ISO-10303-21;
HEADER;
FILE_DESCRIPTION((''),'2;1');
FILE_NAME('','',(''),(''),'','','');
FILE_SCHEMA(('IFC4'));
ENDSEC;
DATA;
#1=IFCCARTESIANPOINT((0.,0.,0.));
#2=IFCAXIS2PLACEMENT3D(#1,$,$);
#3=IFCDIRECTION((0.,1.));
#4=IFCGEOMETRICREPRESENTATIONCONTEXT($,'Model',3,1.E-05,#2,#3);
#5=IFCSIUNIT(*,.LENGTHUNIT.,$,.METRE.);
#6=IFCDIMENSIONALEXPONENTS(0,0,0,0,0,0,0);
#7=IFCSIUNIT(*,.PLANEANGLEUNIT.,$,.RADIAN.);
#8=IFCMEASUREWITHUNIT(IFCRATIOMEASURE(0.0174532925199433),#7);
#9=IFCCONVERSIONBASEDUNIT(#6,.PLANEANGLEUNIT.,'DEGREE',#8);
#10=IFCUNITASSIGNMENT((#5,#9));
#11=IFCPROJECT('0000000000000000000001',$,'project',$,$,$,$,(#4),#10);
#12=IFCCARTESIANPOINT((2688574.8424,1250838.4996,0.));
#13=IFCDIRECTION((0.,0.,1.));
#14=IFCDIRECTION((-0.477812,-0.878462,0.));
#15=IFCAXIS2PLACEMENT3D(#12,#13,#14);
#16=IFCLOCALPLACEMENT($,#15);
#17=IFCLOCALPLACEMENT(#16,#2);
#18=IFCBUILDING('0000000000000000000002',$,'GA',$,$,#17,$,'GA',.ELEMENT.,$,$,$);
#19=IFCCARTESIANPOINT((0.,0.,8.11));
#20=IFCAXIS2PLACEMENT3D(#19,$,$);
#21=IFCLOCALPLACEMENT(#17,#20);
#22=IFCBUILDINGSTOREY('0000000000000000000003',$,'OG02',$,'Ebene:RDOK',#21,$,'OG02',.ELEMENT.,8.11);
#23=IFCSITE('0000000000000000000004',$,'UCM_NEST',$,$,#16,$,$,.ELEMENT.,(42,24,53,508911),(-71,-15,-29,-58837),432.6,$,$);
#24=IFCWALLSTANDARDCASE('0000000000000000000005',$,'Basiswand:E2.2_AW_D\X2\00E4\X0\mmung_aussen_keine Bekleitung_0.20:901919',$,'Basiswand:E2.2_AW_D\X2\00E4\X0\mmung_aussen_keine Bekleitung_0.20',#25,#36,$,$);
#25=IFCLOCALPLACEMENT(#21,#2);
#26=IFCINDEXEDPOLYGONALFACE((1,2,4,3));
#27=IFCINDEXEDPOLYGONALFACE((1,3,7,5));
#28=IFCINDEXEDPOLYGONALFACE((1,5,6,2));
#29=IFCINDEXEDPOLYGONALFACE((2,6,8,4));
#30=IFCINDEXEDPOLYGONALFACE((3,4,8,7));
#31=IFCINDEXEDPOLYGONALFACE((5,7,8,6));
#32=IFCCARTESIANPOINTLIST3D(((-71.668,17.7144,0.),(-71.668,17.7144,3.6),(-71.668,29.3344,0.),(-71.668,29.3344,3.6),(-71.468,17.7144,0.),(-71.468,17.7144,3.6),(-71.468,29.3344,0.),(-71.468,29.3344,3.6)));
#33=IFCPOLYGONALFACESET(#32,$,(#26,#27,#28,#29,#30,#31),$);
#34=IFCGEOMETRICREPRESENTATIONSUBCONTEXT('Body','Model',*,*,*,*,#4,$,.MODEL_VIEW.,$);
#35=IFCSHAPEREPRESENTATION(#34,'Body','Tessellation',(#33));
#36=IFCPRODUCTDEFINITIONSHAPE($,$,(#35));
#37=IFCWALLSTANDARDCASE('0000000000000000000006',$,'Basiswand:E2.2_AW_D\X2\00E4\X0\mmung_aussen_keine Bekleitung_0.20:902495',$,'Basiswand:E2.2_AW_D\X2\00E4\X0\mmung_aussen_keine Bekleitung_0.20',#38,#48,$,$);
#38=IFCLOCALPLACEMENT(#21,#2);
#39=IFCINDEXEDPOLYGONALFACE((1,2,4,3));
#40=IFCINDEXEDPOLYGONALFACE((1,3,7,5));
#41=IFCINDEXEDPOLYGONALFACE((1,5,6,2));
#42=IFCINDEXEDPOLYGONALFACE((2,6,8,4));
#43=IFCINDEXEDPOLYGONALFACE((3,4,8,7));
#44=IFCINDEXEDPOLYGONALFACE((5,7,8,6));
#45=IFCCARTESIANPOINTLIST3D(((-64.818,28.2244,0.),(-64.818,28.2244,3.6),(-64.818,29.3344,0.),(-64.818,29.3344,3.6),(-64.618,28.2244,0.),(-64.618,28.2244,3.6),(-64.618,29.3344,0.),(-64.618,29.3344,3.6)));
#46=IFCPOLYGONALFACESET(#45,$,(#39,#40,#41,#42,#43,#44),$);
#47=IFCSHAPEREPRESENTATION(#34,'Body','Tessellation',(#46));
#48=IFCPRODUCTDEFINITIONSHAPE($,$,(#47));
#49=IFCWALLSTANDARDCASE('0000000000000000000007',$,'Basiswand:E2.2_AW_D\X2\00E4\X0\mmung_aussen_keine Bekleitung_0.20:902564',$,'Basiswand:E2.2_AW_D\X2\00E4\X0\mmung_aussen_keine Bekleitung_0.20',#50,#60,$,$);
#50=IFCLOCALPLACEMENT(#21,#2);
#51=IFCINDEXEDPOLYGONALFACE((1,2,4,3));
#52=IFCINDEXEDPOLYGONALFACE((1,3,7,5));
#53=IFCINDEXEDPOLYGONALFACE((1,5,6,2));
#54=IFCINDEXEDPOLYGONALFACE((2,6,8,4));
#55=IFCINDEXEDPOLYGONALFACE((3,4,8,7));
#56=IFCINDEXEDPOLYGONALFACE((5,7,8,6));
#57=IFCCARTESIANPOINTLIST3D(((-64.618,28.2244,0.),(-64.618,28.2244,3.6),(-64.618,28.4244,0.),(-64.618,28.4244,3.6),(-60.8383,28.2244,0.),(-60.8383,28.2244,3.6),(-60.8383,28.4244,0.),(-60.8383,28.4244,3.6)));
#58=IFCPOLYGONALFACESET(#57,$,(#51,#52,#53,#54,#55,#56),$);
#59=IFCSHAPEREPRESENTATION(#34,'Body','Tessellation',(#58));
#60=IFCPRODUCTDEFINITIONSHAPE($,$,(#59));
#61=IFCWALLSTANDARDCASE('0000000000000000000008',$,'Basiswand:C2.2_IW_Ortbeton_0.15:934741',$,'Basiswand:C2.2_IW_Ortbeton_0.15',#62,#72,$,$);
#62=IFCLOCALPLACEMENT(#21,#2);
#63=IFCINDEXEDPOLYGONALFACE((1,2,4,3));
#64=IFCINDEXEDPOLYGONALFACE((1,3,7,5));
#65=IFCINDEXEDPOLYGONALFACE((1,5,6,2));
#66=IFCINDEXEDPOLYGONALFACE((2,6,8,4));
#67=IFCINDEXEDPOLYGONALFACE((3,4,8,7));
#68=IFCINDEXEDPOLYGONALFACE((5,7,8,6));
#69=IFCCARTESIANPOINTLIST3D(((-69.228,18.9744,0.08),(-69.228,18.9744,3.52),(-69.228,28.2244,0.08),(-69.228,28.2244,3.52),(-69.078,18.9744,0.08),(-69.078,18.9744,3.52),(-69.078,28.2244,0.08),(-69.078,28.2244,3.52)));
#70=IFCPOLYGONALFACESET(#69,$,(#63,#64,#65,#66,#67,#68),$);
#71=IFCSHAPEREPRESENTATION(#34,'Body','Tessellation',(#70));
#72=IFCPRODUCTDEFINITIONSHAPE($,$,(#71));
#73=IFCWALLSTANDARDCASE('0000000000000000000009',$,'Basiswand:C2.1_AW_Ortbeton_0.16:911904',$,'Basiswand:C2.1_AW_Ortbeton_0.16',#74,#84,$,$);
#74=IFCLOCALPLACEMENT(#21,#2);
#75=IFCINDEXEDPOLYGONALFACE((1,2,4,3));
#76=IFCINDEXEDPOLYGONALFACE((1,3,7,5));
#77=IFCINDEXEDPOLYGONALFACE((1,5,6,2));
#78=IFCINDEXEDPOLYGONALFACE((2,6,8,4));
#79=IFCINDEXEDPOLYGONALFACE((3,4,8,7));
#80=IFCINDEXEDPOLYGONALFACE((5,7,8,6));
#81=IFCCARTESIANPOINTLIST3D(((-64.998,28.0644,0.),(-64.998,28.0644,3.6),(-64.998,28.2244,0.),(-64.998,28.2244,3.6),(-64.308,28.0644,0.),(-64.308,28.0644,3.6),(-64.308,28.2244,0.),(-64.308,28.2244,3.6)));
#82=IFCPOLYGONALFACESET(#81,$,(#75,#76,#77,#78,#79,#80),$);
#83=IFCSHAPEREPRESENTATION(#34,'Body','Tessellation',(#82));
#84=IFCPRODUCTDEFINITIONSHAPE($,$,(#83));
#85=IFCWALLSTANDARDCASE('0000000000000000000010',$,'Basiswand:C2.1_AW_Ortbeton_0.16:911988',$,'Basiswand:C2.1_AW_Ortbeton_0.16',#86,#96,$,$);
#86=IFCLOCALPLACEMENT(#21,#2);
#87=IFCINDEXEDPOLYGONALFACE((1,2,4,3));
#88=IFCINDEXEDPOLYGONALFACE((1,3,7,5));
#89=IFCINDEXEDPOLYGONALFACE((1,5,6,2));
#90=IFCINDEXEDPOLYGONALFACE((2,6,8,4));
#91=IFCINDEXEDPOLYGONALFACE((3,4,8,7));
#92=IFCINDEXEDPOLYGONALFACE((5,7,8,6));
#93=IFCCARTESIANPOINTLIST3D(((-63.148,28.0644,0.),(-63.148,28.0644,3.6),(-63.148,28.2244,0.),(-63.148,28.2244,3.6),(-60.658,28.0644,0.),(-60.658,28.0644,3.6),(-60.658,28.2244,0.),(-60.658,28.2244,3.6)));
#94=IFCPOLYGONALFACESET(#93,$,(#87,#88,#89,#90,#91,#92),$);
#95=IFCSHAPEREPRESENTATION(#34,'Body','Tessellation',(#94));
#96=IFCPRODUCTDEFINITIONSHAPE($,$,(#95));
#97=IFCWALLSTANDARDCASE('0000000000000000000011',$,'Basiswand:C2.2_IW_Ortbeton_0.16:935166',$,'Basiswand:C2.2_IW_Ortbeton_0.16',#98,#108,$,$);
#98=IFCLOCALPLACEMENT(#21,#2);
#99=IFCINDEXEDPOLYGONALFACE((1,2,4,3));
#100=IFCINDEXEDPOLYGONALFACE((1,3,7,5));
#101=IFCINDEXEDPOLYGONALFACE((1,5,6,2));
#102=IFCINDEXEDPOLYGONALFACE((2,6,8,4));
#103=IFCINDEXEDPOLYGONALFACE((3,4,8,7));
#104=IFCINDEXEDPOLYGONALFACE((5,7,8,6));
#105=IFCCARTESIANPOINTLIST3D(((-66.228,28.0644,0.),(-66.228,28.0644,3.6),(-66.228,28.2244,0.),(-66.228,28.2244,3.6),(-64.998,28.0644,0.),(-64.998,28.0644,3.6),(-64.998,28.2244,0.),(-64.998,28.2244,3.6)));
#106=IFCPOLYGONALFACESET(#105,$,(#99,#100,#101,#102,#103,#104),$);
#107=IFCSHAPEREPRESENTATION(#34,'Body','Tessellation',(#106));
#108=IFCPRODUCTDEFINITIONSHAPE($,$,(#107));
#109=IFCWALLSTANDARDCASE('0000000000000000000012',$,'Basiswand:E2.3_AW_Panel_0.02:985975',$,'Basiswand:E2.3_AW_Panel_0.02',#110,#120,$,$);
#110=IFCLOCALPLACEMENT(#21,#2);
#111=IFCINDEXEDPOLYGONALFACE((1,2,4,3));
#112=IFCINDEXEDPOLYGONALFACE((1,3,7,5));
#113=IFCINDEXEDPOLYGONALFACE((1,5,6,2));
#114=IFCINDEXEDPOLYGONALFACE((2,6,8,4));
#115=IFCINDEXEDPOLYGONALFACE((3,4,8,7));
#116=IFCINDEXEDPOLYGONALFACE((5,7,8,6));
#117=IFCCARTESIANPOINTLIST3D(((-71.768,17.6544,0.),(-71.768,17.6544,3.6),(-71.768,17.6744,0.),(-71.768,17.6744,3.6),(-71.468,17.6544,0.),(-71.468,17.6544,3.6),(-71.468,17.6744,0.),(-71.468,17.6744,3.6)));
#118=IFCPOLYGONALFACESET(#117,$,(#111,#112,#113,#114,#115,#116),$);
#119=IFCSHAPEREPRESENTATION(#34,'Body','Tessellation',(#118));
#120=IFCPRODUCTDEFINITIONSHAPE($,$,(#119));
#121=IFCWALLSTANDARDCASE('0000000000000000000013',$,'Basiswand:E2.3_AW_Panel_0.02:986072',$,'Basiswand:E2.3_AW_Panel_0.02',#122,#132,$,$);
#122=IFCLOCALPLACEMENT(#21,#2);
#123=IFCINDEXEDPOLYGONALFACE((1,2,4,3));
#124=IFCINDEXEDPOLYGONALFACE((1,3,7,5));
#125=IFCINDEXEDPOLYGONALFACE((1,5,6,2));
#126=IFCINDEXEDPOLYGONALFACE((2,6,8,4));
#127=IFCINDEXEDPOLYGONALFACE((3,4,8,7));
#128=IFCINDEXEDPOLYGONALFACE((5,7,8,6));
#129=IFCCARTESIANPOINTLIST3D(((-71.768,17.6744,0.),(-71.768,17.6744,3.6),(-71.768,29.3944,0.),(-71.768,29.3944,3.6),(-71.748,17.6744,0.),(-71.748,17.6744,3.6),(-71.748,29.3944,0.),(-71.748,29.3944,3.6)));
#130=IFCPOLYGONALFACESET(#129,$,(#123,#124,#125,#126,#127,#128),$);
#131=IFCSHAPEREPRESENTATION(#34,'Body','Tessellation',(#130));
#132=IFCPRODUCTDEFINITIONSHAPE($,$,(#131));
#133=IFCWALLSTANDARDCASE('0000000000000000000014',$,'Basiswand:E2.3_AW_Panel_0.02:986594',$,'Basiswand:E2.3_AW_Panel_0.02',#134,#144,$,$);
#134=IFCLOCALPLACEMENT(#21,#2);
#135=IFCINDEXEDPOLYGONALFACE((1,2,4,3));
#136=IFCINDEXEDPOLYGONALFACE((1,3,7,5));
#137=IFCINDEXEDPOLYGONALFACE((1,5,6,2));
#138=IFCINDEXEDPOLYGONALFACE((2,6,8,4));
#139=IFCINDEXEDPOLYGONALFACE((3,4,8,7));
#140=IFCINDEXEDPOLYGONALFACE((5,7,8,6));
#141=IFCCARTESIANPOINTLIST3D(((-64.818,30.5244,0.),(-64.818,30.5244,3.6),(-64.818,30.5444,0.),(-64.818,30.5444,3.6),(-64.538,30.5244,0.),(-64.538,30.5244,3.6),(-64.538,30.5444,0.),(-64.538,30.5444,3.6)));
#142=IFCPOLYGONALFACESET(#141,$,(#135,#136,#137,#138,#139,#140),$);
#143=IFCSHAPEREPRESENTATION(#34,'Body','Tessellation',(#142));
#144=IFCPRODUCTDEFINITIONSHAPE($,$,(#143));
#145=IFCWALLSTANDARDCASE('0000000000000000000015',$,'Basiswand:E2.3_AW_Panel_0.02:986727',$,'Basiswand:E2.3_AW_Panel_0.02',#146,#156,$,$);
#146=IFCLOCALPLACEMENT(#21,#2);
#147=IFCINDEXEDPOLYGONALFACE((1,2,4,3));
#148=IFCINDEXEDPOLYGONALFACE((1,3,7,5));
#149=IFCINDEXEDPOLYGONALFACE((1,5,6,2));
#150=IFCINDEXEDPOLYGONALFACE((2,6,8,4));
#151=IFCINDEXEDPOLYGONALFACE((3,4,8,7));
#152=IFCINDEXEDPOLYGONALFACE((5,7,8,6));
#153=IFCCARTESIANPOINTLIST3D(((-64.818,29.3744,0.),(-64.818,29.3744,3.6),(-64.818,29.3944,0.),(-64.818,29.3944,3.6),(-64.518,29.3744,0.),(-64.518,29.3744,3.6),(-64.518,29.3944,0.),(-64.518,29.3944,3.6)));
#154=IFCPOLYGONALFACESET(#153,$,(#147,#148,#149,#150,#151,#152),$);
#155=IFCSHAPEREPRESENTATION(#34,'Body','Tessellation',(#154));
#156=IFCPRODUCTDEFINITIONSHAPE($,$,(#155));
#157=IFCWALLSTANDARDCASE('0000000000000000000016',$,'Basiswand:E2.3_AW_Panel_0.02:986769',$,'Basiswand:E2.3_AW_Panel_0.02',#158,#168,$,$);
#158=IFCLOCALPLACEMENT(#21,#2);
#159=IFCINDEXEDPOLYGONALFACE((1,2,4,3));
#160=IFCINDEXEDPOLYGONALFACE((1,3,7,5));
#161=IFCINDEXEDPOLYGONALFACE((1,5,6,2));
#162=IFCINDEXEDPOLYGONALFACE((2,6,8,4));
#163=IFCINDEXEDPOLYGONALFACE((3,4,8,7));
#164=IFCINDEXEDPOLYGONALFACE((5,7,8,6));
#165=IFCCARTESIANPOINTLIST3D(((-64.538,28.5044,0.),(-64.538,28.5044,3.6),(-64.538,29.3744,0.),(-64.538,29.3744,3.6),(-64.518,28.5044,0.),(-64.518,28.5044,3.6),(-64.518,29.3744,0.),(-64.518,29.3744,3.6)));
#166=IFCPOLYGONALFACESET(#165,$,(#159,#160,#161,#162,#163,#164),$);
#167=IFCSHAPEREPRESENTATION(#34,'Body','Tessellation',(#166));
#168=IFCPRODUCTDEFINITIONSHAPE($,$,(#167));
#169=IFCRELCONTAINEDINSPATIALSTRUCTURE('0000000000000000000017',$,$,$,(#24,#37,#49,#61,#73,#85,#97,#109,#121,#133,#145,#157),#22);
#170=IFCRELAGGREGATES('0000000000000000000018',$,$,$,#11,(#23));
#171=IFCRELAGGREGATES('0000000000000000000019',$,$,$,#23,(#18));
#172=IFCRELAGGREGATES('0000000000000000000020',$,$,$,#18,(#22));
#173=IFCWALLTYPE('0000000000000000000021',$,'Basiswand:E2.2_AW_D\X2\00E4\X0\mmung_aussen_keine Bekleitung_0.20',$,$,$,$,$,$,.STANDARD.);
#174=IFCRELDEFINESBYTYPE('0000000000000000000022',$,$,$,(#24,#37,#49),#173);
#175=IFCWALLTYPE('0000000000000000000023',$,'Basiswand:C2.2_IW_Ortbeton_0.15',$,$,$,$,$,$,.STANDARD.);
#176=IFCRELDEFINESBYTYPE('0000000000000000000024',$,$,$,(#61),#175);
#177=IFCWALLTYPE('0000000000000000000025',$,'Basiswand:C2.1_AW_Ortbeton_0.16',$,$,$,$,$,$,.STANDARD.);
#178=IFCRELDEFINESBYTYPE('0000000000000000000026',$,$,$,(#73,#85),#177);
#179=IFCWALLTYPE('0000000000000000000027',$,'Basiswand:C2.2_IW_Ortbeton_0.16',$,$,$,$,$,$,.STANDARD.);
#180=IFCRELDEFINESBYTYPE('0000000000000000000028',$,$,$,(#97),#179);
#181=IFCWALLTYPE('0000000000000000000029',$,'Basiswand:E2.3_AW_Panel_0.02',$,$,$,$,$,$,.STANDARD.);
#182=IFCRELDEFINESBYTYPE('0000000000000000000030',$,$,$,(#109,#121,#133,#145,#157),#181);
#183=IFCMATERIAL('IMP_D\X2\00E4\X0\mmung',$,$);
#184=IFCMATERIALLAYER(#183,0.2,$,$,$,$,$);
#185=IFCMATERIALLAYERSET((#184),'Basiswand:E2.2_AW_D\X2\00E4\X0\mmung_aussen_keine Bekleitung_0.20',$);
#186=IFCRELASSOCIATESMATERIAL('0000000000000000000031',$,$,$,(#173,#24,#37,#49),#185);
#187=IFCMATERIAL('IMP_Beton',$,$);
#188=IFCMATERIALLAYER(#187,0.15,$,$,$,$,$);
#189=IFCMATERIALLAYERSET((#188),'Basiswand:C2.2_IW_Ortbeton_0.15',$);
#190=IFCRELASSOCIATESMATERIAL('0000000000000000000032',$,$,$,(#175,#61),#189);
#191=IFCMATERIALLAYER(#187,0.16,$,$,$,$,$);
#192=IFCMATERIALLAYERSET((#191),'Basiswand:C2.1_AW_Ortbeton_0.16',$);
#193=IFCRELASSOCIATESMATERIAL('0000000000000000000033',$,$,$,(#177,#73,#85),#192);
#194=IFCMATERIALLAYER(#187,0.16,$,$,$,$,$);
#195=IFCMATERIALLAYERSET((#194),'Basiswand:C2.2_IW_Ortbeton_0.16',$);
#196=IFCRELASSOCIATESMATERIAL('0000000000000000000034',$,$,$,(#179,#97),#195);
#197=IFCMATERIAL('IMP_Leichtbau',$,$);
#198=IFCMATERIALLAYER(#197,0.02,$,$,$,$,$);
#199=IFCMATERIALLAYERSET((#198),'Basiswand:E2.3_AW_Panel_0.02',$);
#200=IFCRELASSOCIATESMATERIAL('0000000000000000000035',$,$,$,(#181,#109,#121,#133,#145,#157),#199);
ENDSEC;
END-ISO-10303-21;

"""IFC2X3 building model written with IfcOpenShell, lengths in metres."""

from ifc_helpers import new_model, entity, si_unit, converted_unit, direction, frame, frame_2d, origin, place, context, subcontext, project, spatial, polyline, rectangle, extrude, clip, bounded_halfspace, material, layer, layer_set, layer_usage, type_object, element, save


model = new_model("IFC2X3")

# Units and contexts
model_context = context("Model", 3, precision=1e-05, world=origin(), true_north=direction((0.0, 1.0)))
body_context = subcontext(model_context, "Body", "Model", "MODEL_VIEW")
ifc_project = project(units=[si_unit("LENGTHUNIT", "METRE"), converted_unit("PLANEANGLEUNIT", "DEGREE", entity("IfcRatioMeasure", 0.0174532925199433), si_unit("PLANEANGLEUNIT", "RADIAN"), dimensions=[0, 0, 0, 0, 0, 0, 0])], contexts=[model_context])

# Site, building, storey
site_placement = place(None, frame((2688574.8424, 1250838.4996, 0.0), z_axis=(0.0, 0.0, 1.0), x_axis=(-0.477812, -0.878462, 0.0)))
site = spatial("IfcSite", under=ifc_project, at=site_placement, Name="UCM_NEST", CompositionType="ELEMENT", RefLatitude=(42, 24, 53, 508911), RefLongitude=(-71, -15, -29, -58837), RefElevation=432.6)
building_placement = place(site_placement, origin())
building = spatial("IfcBuilding", under=site, at=building_placement, Name="GA", LongName="GA", CompositionType="ELEMENT")
storey_placement = place(building_placement, frame((0.0, 0.0, 8.11)))
storey = spatial("IfcBuildingStorey", under=building, at=storey_placement, Name="OG02", ObjectType="Ebene:RDOK", LongName="OG02", CompositionType="ELEMENT", Elevation=8.11)

# Walls
ifc_material_1 = material(Name="IMP_Dämmung")
ifc_layer_1 = layer(ifc_material_1, 0.2)
ifc_layer_set_1 = layer_set([ifc_layer_1], Name="Basiswand:E2.2_AW_Dämmung_aussen_keine Bekleitung_0.20")
ifc_layer_usage_1 = layer_usage(ifc_layer_set_1, "AXIS2", "NEGATIVE", 0.1)
wall_type_1 = type_object("IfcWallType", Name="Basiswand:E2.2_AW_Dämmung_aussen_keine Bekleitung_0.20", PredefinedType="STANDARD", material=ifc_layer_set_1)
wall_1_placement = place(storey_placement, frame((-71.568, 17.7144, 0.0), z_axis=(0.0, 0.0, 1.0), x_axis=(0.0, 1.0, 0.0)))
element("IfcWallStandardCase", 1, at=wall_1_placement, inside=storey, type_object=wall_type_1, material=ifc_layer_usage_1, Name="Basiswand:E2.2_AW_Dämmung_aussen_keine Bekleitung_0.20:901919", ObjectType="Basiswand:E2.2_AW_Dämmung_aussen_keine Bekleitung_0.20", context=body_context, shape_type="SweptSolid", body=[
    extrude(rectangle(XDim=11.62, YDim=0.2, at=frame_2d((5.81, 0.0), x_axis=(-1.0, 0.0))), origin(), (0.0, 0.0, 1.0), 3.6),
])
ifc_layer_usage_2 = layer_usage(ifc_layer_set_1, "AXIS2", "NEGATIVE", 0.1)
wall_2_placement = place(storey_placement, frame((-64.718, 29.3344, 0.0), z_axis=(0.0, 0.0, 1.0), x_axis=(0.0, -1.0, 0.0)))
element("IfcWallStandardCase", 2, at=wall_2_placement, inside=storey, type_object=wall_type_1, material=ifc_layer_usage_2, Name="Basiswand:E2.2_AW_Dämmung_aussen_keine Bekleitung_0.20:902495", ObjectType="Basiswand:E2.2_AW_Dämmung_aussen_keine Bekleitung_0.20", context=body_context, shape_type="SweptSolid", body=[
    extrude(rectangle(XDim=1.11, YDim=0.2, at=frame_2d((0.555, 0.0), x_axis=(-1.0, 0.0))), origin(), (0.0, 0.0, 1.0), 3.6),
])
ifc_layer_usage_3 = layer_usage(ifc_layer_set_1, "AXIS2", "NEGATIVE", 0.1)
wall_3_placement = place(storey_placement, frame((-64.618, 28.3244, 0.0)))
element("IfcWallStandardCase", 3, at=wall_3_placement, inside=storey, type_object=wall_type_1, material=ifc_layer_usage_3, Name="Basiswand:E2.2_AW_Dämmung_aussen_keine Bekleitung_0.20:902564", ObjectType="Basiswand:E2.2_AW_Dämmung_aussen_keine Bekleitung_0.20", context=body_context, shape_type="SweptSolid", body=[
    extrude(rectangle(XDim=3.7797, YDim=0.2, at=frame_2d((1.8899, 0.0), x_axis=(-1.0, 0.0))), origin(), (0.0, 0.0, 1.0), 3.6),
])

# Shared definitions
ifc_material_2 = material(Name="IMP_Beton")
ifc_layer_2 = layer(ifc_material_2, 0.15)
ifc_layer_set_2 = layer_set([ifc_layer_2], Name="Basiswand:C2.2_IW_Ortbeton_0.15")
wall_type_2 = type_object("IfcWallType", Name="Basiswand:C2.2_IW_Ortbeton_0.15", PredefinedType="STANDARD", material=ifc_layer_set_2)

# Wall
ifc_layer_usage_4 = layer_usage(ifc_layer_set_2, "AXIS2", "NEGATIVE", 0.075)
wall_4_placement = place(storey_placement, frame((-69.153, 18.9744, 0.08), z_axis=(0.0, 0.0, 1.0), x_axis=(0.0, 1.0, 0.0)))
element("IfcWallStandardCase", 4, at=wall_4_placement, inside=storey, type_object=wall_type_2, material=ifc_layer_usage_4, Name="Basiswand:C2.2_IW_Ortbeton_0.15:934741", ObjectType="Basiswand:C2.2_IW_Ortbeton_0.15", context=body_context, shape_type="Clipping", body=[
    clip(clip(extrude(rectangle(XDim=9.25, YDim=0.15, at=frame_2d((4.625, 0.0), x_axis=(-1.0, 0.0))), origin(), (0.0, 0.0, 1.0), 3.44), bounded_halfspace(frame((9.25, -0.075, 0.0), z_axis=(0.0, 0.0, 1.0), x_axis=(0.0, 1.0, 0.0)), True, frame((9.25, -0.075, 0.0), z_axis=(0.0, 0.0, 1.0), x_axis=(0.0, 1.0, 0.0)), polyline([(0.0, 0.0), (0.15, 0.0), (0.15, 0.15), (0.15, 9.25), (0.0, 9.25), (0.0, 0.0)]))), bounded_halfspace(frame((0.0, -0.075, 3.44), z_axis=(0.0, 0.0, -1.0), x_axis=(0.0, 1.0, 0.0)), True, frame((0.0, -0.075, 3.44), z_axis=(0.0, 0.0, -1.0), x_axis=(0.0, 1.0, 0.0)), polyline([(0.0, 0.0), (0.15, 0.0), (0.15, 9.1), (0.15, 9.25), (0.0, 9.25), (0.0, 0.0)]))),
])

# Walls
ifc_layer_3 = layer(ifc_material_2, 0.16)
ifc_layer_set_3 = layer_set([ifc_layer_3], Name="Basiswand:C2.1_AW_Ortbeton_0.16")
ifc_layer_usage_5 = layer_usage(ifc_layer_set_3, "AXIS2", "NEGATIVE", 0.08)
wall_type_3 = type_object("IfcWallType", Name="Basiswand:C2.1_AW_Ortbeton_0.16", PredefinedType="STANDARD", material=ifc_layer_set_3)
wall_5_placement = place(storey_placement, frame((-64.998, 28.1444, 0.0)))
element("IfcWallStandardCase", 5, at=wall_5_placement, inside=storey, type_object=wall_type_3, material=ifc_layer_usage_5, Name="Basiswand:C2.1_AW_Ortbeton_0.16:911904", ObjectType="Basiswand:C2.1_AW_Ortbeton_0.16", context=body_context, shape_type="SweptSolid", body=[
    extrude(rectangle(XDim=0.69, YDim=0.16, at=frame_2d((0.345, 0.0), x_axis=(-1.0, 0.0))), origin(), (0.0, 0.0, 1.0), 3.6),
])
ifc_layer_usage_6 = layer_usage(ifc_layer_set_3, "AXIS2", "NEGATIVE", 0.08)
wall_6_placement = place(storey_placement, frame((-63.148, 28.1444, 0.0)))
element("IfcWallStandardCase", 6, at=wall_6_placement, inside=storey, type_object=wall_type_3, material=ifc_layer_usage_6, Name="Basiswand:C2.1_AW_Ortbeton_0.16:911988", ObjectType="Basiswand:C2.1_AW_Ortbeton_0.16", context=body_context, shape_type="SweptSolid", body=[
    extrude(rectangle(XDim=2.49, YDim=0.16, at=frame_2d((1.245, 0.0), x_axis=(-1.0, 0.0))), origin(), (0.0, 0.0, 1.0), 3.6),
])
ifc_layer_4 = layer(ifc_material_2, 0.16)
ifc_layer_set_4 = layer_set([ifc_layer_4], Name="Basiswand:C2.2_IW_Ortbeton_0.16")
ifc_layer_usage_7 = layer_usage(ifc_layer_set_4, "AXIS2", "NEGATIVE", 0.08)
wall_type_4 = type_object("IfcWallType", Name="Basiswand:C2.2_IW_Ortbeton_0.16", PredefinedType="STANDARD", material=ifc_layer_set_4)
wall_7_placement = place(storey_placement, frame((-66.228, 28.1444, 0.0)))
element("IfcWallStandardCase", 7, at=wall_7_placement, inside=storey, type_object=wall_type_4, material=ifc_layer_usage_7, Name="Basiswand:C2.2_IW_Ortbeton_0.16:935166", ObjectType="Basiswand:C2.2_IW_Ortbeton_0.16", context=body_context, shape_type="SweptSolid", body=[
    extrude(rectangle(XDim=1.23, YDim=0.16, at=frame_2d((0.615, 0.0), x_axis=(-1.0, 0.0))), origin(), (0.0, 0.0, 1.0), 3.6),
])
ifc_material_3 = material(Name="IMP_Leichtbau")
ifc_layer_5 = layer(ifc_material_3, 0.02)
ifc_layer_set_5 = layer_set([ifc_layer_5], Name="Basiswand:E2.3_AW_Panel_0.02")
ifc_layer_usage_8 = layer_usage(ifc_layer_set_5, "AXIS2", "NEGATIVE", 0.01)
wall_type_5 = type_object("IfcWallType", Name="Basiswand:E2.3_AW_Panel_0.02", PredefinedType="STANDARD", material=ifc_layer_set_5)
wall_8_placement = place(storey_placement, frame((-71.468, 17.6644, 0.0), z_axis=(0.0, 0.0, 1.0), x_axis=(-1.0, 0.0, 0.0)))
element("IfcWallStandardCase", 8, at=wall_8_placement, inside=storey, type_object=wall_type_5, material=ifc_layer_usage_8, Name="Basiswand:E2.3_AW_Panel_0.02:985975", ObjectType="Basiswand:E2.3_AW_Panel_0.02", context=body_context, shape_type="SweptSolid", body=[
    extrude(rectangle(XDim=0.3, YDim=0.02, at=frame_2d((0.15, 0.0), x_axis=(-1.0, 0.0))), origin(), (0.0, 0.0, 1.0), 3.6),
])
ifc_layer_usage_9 = layer_usage(ifc_layer_set_5, "AXIS2", "NEGATIVE", 0.01)
wall_9_placement = place(storey_placement, frame((-71.758, 17.6744, 0.0), z_axis=(0.0, 0.0, 1.0), x_axis=(0.0, 1.0, 0.0)))
element("IfcWallStandardCase", 9, at=wall_9_placement, inside=storey, type_object=wall_type_5, material=ifc_layer_usage_9, Name="Basiswand:E2.3_AW_Panel_0.02:986072", ObjectType="Basiswand:E2.3_AW_Panel_0.02", context=body_context, shape_type="SweptSolid", body=[
    extrude(rectangle(XDim=11.72, YDim=0.02, at=frame_2d((5.86, 0.0), x_axis=(-1.0, 0.0))), origin(), (0.0, 0.0, 1.0), 3.6),
])
ifc_layer_usage_10 = layer_usage(ifc_layer_set_5, "AXIS2", "NEGATIVE", 0.01)
wall_10_placement = place(storey_placement, frame((-64.538, 30.5344, 0.0), z_axis=(0.0, 0.0, 1.0), x_axis=(-1.0, 0.0, 0.0)))
element("IfcWallStandardCase", 10, at=wall_10_placement, inside=storey, type_object=wall_type_5, material=ifc_layer_usage_10, Name="Basiswand:E2.3_AW_Panel_0.02:986594", ObjectType="Basiswand:E2.3_AW_Panel_0.02", context=body_context, shape_type="SweptSolid", body=[
    extrude(rectangle(XDim=0.28, YDim=0.02, at=frame_2d((0.14, 0.0), x_axis=(-1.0, 0.0))), origin(), (0.0, 0.0, 1.0), 3.6),
])
ifc_layer_usage_11 = layer_usage(ifc_layer_set_5, "AXIS2", "NEGATIVE", 0.01)
wall_11_placement = place(storey_placement, frame((-64.818, 29.3844, 0.0)))
element("IfcWallStandardCase", 11, at=wall_11_placement, inside=storey, type_object=wall_type_5, material=ifc_layer_usage_11, Name="Basiswand:E2.3_AW_Panel_0.02:986727", ObjectType="Basiswand:E2.3_AW_Panel_0.02", context=body_context, shape_type="SweptSolid", body=[
    extrude(rectangle(XDim=0.3, YDim=0.02, at=frame_2d((0.15, 0.0), x_axis=(-1.0, 0.0))), origin(), (0.0, 0.0, 1.0), 3.6),
])
ifc_layer_usage_12 = layer_usage(ifc_layer_set_5, "AXIS2", "NEGATIVE", 0.01)
wall_12_placement = place(storey_placement, frame((-64.528, 29.3744, 0.0), z_axis=(0.0, 0.0, 1.0), x_axis=(0.0, -1.0, 0.0)))
element("IfcWallStandardCase", 12, at=wall_12_placement, inside=storey, type_object=wall_type_5, material=ifc_layer_usage_12, Name="Basiswand:E2.3_AW_Panel_0.02:986769", ObjectType="Basiswand:E2.3_AW_Panel_0.02", context=body_context, shape_type="SweptSolid", body=[
    extrude(rectangle(XDim=0.87, YDim=0.02, at=frame_2d((0.435, 0.0), x_axis=(-1.0, 0.0))), origin(), (0.0, 0.0, 1.0), 3.6),
])

save(model, "model.ifc")
